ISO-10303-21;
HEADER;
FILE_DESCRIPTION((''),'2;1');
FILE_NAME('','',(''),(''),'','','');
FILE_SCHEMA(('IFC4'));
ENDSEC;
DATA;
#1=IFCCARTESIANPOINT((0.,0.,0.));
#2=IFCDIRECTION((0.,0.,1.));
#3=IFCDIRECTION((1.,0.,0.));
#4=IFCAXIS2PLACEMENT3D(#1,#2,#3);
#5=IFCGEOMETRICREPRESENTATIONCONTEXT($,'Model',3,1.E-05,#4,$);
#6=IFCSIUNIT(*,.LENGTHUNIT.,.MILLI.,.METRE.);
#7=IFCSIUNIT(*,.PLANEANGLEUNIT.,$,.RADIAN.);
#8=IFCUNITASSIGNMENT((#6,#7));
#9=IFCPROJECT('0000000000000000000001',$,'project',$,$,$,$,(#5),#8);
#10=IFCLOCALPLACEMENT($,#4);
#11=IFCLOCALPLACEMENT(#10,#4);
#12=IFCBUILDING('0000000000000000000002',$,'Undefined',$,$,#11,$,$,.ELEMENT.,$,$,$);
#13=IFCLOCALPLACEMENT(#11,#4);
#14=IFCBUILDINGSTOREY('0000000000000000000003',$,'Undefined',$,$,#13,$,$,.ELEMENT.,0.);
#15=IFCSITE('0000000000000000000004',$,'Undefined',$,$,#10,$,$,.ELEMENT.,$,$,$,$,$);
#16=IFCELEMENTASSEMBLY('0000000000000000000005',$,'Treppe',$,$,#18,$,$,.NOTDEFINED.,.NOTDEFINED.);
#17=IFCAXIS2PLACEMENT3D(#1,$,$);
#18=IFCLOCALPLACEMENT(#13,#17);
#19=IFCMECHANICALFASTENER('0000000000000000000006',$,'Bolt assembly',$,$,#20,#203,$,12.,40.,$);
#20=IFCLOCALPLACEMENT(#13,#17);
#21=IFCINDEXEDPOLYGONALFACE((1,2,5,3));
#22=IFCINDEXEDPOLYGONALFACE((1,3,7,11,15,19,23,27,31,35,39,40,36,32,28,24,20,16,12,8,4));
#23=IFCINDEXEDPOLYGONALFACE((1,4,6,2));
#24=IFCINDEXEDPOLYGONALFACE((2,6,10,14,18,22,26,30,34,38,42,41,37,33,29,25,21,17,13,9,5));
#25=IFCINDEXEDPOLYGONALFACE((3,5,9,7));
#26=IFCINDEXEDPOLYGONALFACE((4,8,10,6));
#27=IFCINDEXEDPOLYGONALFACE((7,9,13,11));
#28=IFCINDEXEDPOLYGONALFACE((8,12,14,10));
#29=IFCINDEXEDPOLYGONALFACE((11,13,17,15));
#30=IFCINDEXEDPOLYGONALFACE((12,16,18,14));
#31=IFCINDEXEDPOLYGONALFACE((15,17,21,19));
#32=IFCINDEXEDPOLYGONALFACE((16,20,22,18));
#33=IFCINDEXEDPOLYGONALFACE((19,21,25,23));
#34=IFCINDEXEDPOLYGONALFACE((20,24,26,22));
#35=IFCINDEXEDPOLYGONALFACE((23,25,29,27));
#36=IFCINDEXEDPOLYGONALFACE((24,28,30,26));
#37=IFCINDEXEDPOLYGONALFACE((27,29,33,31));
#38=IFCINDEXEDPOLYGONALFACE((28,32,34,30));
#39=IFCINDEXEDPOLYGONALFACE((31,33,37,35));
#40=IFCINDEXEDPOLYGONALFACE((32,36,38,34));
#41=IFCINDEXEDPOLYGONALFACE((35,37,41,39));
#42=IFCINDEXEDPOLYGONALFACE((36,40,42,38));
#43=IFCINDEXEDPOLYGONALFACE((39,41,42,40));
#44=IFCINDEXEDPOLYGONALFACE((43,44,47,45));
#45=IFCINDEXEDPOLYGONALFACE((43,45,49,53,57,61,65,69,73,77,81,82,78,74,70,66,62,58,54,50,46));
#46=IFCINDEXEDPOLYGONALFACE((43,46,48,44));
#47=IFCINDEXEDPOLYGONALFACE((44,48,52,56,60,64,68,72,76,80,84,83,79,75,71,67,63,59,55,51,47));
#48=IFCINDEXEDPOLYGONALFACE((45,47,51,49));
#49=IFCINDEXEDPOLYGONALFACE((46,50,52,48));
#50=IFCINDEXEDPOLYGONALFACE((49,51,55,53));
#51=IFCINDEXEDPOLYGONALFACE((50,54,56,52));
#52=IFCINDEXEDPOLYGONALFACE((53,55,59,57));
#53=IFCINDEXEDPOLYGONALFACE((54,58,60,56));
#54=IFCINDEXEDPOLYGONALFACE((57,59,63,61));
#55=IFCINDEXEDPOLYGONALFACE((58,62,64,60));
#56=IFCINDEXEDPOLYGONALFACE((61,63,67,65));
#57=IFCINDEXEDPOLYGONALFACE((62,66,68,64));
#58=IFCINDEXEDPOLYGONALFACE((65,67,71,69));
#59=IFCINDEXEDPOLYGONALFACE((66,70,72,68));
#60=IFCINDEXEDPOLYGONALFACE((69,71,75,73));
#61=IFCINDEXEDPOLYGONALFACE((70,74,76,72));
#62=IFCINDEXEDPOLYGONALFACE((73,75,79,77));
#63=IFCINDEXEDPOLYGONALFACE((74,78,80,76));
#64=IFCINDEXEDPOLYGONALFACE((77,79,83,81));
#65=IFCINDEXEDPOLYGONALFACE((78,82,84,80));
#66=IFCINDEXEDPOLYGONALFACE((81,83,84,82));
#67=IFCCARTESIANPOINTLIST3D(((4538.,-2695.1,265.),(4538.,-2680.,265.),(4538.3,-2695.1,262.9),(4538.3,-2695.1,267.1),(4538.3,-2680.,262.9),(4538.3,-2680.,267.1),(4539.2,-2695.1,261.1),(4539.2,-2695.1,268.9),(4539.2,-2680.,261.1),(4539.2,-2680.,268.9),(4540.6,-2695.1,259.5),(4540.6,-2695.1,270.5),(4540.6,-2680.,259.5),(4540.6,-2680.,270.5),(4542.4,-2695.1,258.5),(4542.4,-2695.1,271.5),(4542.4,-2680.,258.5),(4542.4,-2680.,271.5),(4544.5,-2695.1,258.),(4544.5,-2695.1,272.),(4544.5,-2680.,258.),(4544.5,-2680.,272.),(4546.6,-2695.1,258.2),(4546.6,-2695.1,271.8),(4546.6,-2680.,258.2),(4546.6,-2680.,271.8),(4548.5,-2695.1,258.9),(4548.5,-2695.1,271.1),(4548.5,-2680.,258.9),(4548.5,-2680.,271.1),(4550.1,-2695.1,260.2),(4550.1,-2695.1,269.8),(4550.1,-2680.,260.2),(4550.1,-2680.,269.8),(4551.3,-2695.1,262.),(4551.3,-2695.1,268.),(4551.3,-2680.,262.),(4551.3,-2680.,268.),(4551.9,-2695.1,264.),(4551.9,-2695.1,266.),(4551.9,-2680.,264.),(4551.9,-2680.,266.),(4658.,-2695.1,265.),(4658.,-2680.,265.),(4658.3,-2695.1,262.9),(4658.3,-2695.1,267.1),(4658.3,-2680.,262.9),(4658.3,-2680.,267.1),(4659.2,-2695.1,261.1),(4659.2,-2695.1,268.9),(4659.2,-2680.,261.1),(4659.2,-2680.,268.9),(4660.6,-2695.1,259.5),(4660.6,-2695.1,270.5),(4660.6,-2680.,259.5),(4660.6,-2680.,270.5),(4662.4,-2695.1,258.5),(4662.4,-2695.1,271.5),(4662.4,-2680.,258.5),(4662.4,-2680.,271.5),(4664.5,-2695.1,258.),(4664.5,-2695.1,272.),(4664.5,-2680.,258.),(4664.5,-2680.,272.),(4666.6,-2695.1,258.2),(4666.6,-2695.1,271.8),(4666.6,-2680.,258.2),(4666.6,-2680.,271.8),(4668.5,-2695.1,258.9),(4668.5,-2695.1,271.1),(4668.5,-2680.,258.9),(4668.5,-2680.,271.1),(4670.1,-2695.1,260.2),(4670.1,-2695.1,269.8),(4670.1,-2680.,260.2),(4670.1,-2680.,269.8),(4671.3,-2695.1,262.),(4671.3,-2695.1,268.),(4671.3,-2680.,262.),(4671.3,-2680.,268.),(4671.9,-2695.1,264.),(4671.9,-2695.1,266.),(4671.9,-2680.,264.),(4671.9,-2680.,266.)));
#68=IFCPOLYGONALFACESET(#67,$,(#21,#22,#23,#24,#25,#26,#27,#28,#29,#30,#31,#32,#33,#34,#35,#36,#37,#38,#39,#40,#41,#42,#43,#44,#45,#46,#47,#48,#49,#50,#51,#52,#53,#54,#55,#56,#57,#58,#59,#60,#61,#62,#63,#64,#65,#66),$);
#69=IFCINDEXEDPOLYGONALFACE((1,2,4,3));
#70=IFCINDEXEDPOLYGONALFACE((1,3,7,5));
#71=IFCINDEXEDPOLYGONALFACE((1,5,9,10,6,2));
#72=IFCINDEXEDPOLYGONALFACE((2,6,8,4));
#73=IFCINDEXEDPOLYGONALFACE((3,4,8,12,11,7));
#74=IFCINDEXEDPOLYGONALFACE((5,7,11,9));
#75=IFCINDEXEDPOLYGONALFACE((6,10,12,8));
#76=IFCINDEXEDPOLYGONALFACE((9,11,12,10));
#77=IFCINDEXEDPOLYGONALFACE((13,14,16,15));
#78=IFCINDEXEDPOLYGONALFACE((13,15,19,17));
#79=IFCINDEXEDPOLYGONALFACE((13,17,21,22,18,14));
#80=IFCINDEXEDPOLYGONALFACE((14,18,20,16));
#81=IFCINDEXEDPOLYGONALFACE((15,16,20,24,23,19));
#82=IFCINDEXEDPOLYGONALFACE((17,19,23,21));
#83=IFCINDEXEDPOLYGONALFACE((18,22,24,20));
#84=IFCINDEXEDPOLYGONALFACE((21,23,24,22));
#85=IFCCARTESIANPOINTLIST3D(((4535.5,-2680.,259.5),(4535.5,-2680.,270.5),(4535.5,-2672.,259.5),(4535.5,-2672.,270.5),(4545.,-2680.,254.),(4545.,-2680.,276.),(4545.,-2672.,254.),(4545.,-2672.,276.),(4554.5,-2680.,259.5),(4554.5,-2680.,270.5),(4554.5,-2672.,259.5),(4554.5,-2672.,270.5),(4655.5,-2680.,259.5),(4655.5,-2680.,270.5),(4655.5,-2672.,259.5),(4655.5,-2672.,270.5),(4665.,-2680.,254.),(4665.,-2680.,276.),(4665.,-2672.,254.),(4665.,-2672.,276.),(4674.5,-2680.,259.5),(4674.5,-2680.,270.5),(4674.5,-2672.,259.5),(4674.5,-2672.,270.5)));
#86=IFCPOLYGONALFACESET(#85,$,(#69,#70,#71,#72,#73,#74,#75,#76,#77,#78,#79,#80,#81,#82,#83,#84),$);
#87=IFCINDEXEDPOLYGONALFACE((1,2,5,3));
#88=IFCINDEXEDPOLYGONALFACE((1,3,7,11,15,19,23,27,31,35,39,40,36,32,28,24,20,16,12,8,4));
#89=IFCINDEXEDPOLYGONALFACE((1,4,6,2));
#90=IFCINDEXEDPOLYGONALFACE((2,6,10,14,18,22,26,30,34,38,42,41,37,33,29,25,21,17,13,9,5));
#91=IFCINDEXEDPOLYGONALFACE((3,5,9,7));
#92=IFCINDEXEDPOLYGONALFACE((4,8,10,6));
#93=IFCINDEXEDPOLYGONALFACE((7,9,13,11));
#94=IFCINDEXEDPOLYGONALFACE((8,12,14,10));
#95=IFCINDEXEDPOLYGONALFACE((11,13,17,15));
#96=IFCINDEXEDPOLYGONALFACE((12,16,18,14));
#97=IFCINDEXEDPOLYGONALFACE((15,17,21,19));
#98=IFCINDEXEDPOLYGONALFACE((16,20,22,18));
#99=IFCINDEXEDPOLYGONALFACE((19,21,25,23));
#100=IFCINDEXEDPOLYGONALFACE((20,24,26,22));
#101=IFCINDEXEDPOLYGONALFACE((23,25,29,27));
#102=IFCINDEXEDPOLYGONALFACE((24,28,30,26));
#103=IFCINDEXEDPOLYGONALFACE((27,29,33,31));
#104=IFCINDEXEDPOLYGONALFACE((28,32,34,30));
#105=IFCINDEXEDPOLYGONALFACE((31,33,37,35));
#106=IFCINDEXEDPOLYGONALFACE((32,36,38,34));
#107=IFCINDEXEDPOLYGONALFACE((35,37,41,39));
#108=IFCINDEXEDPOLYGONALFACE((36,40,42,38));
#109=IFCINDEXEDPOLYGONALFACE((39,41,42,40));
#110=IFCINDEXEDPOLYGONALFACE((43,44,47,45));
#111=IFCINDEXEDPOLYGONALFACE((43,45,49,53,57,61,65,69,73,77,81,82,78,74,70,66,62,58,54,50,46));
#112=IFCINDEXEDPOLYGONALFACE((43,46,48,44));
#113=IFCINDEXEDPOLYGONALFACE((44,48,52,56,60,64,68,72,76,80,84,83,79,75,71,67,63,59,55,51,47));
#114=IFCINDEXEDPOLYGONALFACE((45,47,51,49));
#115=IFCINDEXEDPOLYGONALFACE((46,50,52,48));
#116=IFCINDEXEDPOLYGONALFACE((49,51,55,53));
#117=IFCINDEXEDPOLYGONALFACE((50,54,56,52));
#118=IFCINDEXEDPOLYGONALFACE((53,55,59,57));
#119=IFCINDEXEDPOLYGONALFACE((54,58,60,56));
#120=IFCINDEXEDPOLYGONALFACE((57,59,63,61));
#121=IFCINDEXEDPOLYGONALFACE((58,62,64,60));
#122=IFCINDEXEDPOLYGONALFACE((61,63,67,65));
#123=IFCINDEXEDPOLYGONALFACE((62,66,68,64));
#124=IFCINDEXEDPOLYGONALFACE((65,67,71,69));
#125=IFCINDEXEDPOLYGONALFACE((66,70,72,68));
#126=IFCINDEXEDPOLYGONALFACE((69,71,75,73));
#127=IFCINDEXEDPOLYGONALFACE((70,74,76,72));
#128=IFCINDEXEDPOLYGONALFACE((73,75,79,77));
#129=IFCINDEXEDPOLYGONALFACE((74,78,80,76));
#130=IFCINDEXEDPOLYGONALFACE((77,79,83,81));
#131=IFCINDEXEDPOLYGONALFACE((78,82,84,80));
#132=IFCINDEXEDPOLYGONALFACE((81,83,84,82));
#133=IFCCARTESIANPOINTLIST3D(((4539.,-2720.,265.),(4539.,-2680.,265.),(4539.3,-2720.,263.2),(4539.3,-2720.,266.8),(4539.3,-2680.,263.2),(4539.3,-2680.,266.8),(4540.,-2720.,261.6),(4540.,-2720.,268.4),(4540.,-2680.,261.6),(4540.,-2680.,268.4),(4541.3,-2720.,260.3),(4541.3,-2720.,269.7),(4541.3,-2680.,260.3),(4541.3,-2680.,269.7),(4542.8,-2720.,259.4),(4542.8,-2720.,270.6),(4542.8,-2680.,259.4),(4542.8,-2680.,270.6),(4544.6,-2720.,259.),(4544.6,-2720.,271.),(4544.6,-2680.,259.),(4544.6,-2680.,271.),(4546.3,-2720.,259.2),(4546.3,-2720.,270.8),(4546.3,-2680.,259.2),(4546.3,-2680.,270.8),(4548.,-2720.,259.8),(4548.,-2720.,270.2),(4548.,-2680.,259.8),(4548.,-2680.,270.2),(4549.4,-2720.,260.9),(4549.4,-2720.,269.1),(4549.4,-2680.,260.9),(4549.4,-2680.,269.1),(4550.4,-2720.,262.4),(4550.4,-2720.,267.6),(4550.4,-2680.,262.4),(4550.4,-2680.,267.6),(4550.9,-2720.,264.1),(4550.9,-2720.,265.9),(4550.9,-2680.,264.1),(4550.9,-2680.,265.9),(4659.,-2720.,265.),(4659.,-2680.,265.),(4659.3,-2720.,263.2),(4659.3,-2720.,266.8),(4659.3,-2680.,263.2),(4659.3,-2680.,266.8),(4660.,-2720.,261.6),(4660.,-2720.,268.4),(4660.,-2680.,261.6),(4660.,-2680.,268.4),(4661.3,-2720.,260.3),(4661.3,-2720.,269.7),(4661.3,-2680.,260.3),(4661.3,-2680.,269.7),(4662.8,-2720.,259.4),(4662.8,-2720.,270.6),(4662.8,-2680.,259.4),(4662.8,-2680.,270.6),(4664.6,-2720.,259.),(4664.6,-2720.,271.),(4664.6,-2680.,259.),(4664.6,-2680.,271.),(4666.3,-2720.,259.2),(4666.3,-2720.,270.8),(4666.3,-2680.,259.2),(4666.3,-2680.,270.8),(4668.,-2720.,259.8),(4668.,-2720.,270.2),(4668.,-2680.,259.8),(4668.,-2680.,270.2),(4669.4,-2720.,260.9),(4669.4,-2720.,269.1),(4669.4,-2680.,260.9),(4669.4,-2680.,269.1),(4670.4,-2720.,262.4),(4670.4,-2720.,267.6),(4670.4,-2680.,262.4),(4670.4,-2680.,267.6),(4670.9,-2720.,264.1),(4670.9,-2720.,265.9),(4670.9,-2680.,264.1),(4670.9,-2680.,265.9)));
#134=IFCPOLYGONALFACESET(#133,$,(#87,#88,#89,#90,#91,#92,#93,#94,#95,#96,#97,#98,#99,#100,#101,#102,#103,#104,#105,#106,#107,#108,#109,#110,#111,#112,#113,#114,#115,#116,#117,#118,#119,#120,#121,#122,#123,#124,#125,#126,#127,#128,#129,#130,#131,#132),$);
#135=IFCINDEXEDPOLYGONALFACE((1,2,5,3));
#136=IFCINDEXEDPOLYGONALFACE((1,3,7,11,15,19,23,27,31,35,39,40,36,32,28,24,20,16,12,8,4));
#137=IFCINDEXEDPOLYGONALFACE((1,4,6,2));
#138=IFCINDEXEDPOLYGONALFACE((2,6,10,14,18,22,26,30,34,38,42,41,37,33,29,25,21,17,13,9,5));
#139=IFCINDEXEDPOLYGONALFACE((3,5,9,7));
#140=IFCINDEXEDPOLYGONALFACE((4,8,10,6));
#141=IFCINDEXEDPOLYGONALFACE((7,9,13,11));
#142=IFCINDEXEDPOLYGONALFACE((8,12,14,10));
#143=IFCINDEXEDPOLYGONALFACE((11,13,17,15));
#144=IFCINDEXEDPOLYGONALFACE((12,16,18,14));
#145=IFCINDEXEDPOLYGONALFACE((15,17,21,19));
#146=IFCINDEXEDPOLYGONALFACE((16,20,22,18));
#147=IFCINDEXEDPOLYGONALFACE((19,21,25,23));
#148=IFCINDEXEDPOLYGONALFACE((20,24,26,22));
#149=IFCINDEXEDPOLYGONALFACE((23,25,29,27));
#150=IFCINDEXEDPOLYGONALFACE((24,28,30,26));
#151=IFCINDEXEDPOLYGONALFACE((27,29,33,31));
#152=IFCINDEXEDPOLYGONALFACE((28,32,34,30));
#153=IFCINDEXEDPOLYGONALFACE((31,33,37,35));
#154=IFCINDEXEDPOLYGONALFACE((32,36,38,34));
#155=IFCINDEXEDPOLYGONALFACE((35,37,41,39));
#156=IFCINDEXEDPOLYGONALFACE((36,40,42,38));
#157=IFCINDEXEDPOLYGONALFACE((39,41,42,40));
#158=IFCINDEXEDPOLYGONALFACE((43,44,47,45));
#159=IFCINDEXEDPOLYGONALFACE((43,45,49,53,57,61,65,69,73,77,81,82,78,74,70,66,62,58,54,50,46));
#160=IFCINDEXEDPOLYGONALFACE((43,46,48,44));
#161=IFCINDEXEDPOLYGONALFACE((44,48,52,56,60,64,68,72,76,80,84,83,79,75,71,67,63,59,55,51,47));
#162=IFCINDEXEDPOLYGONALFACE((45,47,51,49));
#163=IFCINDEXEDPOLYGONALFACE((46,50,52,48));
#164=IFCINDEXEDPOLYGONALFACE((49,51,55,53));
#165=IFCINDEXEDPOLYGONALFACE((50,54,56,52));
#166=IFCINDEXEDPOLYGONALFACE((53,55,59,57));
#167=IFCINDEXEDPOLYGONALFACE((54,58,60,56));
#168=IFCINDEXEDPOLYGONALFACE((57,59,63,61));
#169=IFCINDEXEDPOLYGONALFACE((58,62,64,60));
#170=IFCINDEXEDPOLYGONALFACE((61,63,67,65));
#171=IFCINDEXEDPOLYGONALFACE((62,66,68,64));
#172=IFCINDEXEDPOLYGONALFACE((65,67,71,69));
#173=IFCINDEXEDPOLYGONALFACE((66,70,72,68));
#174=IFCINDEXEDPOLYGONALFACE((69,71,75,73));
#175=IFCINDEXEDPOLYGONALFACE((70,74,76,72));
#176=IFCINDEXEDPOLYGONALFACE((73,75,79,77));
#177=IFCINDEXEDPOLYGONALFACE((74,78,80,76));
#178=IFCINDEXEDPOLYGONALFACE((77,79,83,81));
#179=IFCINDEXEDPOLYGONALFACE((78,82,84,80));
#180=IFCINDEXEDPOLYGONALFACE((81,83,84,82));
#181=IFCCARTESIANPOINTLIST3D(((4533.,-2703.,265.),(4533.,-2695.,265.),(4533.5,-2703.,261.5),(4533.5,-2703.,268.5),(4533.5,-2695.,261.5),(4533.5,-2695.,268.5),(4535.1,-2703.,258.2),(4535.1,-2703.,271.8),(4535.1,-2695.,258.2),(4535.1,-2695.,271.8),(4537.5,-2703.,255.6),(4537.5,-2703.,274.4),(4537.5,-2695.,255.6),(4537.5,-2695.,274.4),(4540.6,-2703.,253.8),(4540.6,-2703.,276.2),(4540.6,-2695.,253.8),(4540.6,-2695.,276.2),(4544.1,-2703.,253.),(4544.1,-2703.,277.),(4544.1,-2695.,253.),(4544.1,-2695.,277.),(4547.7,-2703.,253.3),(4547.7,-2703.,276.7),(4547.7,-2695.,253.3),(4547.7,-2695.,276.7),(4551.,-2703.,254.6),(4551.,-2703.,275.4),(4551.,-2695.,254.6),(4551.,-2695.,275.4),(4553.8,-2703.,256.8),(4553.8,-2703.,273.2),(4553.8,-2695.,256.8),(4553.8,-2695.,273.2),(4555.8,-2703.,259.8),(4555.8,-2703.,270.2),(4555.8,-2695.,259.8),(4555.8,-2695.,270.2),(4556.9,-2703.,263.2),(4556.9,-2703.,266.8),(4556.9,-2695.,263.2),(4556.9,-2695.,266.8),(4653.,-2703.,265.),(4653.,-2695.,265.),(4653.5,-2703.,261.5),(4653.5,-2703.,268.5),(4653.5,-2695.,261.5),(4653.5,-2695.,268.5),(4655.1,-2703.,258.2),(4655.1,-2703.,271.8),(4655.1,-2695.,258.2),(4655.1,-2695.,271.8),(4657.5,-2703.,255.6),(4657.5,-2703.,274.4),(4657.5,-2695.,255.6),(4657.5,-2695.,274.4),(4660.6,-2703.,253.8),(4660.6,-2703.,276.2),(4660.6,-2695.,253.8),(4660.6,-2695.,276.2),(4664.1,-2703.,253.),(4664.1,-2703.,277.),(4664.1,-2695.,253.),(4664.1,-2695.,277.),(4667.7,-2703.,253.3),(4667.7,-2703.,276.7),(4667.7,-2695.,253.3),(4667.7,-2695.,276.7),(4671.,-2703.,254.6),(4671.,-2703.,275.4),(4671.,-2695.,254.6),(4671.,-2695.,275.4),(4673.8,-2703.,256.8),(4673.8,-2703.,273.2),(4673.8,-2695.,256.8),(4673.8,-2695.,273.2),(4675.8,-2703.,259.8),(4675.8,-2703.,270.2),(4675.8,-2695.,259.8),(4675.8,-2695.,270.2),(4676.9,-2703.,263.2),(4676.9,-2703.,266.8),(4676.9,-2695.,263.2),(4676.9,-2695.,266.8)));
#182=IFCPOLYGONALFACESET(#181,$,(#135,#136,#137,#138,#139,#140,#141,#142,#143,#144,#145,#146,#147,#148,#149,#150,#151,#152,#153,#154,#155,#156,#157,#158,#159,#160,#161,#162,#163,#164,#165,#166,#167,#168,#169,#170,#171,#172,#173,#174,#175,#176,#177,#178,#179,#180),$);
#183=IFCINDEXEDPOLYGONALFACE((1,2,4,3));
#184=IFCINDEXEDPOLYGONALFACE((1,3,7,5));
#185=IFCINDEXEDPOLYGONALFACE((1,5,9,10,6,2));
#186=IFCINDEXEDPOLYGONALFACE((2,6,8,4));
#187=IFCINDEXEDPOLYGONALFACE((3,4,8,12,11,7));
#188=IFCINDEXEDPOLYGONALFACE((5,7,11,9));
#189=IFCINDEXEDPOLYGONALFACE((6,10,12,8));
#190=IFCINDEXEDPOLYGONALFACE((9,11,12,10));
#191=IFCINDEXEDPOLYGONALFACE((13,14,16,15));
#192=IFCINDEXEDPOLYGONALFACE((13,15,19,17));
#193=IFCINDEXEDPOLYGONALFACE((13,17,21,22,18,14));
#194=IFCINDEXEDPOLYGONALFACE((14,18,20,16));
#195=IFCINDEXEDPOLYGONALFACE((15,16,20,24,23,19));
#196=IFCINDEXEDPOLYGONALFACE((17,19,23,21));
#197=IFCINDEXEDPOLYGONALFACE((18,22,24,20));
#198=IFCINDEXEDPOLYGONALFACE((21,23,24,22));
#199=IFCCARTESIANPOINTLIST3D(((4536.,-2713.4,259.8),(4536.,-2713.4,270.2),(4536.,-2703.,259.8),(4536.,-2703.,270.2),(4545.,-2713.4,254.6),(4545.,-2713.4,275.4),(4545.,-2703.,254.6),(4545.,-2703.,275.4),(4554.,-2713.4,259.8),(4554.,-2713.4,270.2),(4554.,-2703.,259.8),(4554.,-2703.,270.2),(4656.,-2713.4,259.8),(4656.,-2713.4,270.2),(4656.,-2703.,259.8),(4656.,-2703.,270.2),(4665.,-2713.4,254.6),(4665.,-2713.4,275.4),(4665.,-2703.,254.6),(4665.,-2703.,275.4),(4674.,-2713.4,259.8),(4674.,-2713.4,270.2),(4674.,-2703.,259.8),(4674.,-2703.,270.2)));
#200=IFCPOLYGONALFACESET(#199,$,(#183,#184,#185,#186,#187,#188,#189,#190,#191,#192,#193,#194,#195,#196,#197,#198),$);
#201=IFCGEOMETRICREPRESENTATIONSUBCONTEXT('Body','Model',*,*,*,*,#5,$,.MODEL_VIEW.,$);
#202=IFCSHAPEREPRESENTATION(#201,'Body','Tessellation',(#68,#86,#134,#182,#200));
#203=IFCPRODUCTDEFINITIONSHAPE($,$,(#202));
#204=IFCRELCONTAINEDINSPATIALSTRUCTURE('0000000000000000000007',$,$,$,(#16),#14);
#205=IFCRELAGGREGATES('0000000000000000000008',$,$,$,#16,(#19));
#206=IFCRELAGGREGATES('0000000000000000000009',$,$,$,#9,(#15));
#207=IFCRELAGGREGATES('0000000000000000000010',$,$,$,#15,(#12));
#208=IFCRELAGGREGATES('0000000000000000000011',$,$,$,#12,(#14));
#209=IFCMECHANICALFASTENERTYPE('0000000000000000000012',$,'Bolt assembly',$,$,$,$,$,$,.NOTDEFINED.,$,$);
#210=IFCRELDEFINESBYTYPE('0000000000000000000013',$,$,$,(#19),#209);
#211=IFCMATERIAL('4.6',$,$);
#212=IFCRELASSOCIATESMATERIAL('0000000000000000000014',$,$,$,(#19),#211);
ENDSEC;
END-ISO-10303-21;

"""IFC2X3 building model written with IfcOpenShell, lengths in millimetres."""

from ifc_helpers import new_model, si_unit, frame, origin_with_axes, origin_2d_with_axis, place, context, subcontext, project, spatial, polyline, circle, outline, extrude, source, transform, mapped, material, type_object, element, aggregate, save


model = new_model("IFC2X3")

# Units and contexts
model_context = context("Model", 3, precision=1e-05, world=origin_with_axes())
body_context = subcontext(model_context, "Body", "Model", "MODEL_VIEW")
ifc_project = project(units=[si_unit("LENGTHUNIT", "METRE", prefix="MILLI"), si_unit("PLANEANGLEUNIT", "RADIAN")], contexts=[model_context])

# Site, building, storey
site_placement = place(None, origin_with_axes())
site = spatial("IfcSite", under=ifc_project, at=site_placement, Name="Undefined", CompositionType="ELEMENT")
building_placement = place(site_placement, origin_with_axes())
building = spatial("IfcBuilding", under=site, at=building_placement, Name="Undefined", CompositionType="ELEMENT")
storey_placement = place(building_placement, origin_with_axes())
storey = spatial("IfcBuildingStorey", under=building, at=storey_placement, Name="Undefined", CompositionType="ELEMENT", Elevation=0.0)

# Element assembly
assembly_1_placement = place(storey_placement, origin_with_axes())
assembly_1 = element("IfcElementAssembly", 1, at=assembly_1_placement, inside=storey, Name="Treppe", AssemblyPlace="NOTDEFINED", PredefinedType="NOTDEFINED")

# Mechanical fastener
ifc_material_1 = material(Name="4.6")
mechanical_fastener_type = type_object("IfcMechanicalFastenerType", Name="Bolt assembly")
shared_shape_1 = source(origin_with_axes(), body_context, "Body", "SweptSolid", [
    extrude(circle(Radius=7.0, at=origin_2d_with_axis()), frame((0.0, -15.0, 0.0), z_axis=(0.0, 1.0, 0.0), x_axis=(1.0, 0.0, 0.0)), (0.0, 0.0, 1.0), 15.1),
    extrude(outline(polyline([(9.5, -5.5), (9.5, 5.5), (0.0, 11.0), (-9.5, 5.5), (-9.5, -5.5), (0.0, -11.0), (9.5, -5.5)])), frame((0.0, -23.0, 0.0), z_axis=(0.0, 1.0, 0.0), x_axis=(1.0, 0.0, 0.0)), (0.0, 0.0, 1.0), 8.0),
    extrude(circle(Radius=6.0, at=origin_2d_with_axis()), frame((0.0, -15.0, 0.0), z_axis=(0.0, 1.0, 0.0), x_axis=(1.0, 0.0, 0.0)), (0.0, 0.0, 1.0), 40.0),
    extrude(circle(Radius=12.0, at=origin_2d_with_axis()), frame((0.0, 0.0, 0.0), z_axis=(0.0, 1.0, 0.0), x_axis=(1.0, 0.0, 0.0)), (0.0, 0.0, 1.0), 8.0),
    extrude(outline(polyline([(9.0, -5.2), (9.0, 5.2), (0.0, 10.4), (-9.0, 5.2), (-9.0, -5.2), (0.0, -10.4), (9.0, -5.2)])), frame((0.0, 8.0, 0.0), z_axis=(0.0, 1.0, 0.0), x_axis=(1.0, 0.0, 0.0)), (0.0, 0.0, 1.0), 10.4),
])
mechanical_fastener_1_placement = place(assembly_1_placement, frame((4665.0, -2695.0, 265.0), z_axis=(0.0, 0.0, 1.0), x_axis=(-1.0, 0.0, 0.0)))
mechanical_fastener_1 = element("IfcMechanicalFastener", 2, at=mechanical_fastener_1_placement, type_object=mechanical_fastener_type, material=ifc_material_1, Name="Bolt assembly", NominalDiameter=12.0, NominalLength=40.0, context=body_context, shape_type="MappedRepresentation", body=[
    mapped(shared_shape_1, transform((0.0, 0.0, 0.0))),
    mapped(shared_shape_1, transform((120.0, 0.0, 0.0))),
])
aggregate(assembly_1, [mechanical_fastener_1])

save(model, "model.ifc")
